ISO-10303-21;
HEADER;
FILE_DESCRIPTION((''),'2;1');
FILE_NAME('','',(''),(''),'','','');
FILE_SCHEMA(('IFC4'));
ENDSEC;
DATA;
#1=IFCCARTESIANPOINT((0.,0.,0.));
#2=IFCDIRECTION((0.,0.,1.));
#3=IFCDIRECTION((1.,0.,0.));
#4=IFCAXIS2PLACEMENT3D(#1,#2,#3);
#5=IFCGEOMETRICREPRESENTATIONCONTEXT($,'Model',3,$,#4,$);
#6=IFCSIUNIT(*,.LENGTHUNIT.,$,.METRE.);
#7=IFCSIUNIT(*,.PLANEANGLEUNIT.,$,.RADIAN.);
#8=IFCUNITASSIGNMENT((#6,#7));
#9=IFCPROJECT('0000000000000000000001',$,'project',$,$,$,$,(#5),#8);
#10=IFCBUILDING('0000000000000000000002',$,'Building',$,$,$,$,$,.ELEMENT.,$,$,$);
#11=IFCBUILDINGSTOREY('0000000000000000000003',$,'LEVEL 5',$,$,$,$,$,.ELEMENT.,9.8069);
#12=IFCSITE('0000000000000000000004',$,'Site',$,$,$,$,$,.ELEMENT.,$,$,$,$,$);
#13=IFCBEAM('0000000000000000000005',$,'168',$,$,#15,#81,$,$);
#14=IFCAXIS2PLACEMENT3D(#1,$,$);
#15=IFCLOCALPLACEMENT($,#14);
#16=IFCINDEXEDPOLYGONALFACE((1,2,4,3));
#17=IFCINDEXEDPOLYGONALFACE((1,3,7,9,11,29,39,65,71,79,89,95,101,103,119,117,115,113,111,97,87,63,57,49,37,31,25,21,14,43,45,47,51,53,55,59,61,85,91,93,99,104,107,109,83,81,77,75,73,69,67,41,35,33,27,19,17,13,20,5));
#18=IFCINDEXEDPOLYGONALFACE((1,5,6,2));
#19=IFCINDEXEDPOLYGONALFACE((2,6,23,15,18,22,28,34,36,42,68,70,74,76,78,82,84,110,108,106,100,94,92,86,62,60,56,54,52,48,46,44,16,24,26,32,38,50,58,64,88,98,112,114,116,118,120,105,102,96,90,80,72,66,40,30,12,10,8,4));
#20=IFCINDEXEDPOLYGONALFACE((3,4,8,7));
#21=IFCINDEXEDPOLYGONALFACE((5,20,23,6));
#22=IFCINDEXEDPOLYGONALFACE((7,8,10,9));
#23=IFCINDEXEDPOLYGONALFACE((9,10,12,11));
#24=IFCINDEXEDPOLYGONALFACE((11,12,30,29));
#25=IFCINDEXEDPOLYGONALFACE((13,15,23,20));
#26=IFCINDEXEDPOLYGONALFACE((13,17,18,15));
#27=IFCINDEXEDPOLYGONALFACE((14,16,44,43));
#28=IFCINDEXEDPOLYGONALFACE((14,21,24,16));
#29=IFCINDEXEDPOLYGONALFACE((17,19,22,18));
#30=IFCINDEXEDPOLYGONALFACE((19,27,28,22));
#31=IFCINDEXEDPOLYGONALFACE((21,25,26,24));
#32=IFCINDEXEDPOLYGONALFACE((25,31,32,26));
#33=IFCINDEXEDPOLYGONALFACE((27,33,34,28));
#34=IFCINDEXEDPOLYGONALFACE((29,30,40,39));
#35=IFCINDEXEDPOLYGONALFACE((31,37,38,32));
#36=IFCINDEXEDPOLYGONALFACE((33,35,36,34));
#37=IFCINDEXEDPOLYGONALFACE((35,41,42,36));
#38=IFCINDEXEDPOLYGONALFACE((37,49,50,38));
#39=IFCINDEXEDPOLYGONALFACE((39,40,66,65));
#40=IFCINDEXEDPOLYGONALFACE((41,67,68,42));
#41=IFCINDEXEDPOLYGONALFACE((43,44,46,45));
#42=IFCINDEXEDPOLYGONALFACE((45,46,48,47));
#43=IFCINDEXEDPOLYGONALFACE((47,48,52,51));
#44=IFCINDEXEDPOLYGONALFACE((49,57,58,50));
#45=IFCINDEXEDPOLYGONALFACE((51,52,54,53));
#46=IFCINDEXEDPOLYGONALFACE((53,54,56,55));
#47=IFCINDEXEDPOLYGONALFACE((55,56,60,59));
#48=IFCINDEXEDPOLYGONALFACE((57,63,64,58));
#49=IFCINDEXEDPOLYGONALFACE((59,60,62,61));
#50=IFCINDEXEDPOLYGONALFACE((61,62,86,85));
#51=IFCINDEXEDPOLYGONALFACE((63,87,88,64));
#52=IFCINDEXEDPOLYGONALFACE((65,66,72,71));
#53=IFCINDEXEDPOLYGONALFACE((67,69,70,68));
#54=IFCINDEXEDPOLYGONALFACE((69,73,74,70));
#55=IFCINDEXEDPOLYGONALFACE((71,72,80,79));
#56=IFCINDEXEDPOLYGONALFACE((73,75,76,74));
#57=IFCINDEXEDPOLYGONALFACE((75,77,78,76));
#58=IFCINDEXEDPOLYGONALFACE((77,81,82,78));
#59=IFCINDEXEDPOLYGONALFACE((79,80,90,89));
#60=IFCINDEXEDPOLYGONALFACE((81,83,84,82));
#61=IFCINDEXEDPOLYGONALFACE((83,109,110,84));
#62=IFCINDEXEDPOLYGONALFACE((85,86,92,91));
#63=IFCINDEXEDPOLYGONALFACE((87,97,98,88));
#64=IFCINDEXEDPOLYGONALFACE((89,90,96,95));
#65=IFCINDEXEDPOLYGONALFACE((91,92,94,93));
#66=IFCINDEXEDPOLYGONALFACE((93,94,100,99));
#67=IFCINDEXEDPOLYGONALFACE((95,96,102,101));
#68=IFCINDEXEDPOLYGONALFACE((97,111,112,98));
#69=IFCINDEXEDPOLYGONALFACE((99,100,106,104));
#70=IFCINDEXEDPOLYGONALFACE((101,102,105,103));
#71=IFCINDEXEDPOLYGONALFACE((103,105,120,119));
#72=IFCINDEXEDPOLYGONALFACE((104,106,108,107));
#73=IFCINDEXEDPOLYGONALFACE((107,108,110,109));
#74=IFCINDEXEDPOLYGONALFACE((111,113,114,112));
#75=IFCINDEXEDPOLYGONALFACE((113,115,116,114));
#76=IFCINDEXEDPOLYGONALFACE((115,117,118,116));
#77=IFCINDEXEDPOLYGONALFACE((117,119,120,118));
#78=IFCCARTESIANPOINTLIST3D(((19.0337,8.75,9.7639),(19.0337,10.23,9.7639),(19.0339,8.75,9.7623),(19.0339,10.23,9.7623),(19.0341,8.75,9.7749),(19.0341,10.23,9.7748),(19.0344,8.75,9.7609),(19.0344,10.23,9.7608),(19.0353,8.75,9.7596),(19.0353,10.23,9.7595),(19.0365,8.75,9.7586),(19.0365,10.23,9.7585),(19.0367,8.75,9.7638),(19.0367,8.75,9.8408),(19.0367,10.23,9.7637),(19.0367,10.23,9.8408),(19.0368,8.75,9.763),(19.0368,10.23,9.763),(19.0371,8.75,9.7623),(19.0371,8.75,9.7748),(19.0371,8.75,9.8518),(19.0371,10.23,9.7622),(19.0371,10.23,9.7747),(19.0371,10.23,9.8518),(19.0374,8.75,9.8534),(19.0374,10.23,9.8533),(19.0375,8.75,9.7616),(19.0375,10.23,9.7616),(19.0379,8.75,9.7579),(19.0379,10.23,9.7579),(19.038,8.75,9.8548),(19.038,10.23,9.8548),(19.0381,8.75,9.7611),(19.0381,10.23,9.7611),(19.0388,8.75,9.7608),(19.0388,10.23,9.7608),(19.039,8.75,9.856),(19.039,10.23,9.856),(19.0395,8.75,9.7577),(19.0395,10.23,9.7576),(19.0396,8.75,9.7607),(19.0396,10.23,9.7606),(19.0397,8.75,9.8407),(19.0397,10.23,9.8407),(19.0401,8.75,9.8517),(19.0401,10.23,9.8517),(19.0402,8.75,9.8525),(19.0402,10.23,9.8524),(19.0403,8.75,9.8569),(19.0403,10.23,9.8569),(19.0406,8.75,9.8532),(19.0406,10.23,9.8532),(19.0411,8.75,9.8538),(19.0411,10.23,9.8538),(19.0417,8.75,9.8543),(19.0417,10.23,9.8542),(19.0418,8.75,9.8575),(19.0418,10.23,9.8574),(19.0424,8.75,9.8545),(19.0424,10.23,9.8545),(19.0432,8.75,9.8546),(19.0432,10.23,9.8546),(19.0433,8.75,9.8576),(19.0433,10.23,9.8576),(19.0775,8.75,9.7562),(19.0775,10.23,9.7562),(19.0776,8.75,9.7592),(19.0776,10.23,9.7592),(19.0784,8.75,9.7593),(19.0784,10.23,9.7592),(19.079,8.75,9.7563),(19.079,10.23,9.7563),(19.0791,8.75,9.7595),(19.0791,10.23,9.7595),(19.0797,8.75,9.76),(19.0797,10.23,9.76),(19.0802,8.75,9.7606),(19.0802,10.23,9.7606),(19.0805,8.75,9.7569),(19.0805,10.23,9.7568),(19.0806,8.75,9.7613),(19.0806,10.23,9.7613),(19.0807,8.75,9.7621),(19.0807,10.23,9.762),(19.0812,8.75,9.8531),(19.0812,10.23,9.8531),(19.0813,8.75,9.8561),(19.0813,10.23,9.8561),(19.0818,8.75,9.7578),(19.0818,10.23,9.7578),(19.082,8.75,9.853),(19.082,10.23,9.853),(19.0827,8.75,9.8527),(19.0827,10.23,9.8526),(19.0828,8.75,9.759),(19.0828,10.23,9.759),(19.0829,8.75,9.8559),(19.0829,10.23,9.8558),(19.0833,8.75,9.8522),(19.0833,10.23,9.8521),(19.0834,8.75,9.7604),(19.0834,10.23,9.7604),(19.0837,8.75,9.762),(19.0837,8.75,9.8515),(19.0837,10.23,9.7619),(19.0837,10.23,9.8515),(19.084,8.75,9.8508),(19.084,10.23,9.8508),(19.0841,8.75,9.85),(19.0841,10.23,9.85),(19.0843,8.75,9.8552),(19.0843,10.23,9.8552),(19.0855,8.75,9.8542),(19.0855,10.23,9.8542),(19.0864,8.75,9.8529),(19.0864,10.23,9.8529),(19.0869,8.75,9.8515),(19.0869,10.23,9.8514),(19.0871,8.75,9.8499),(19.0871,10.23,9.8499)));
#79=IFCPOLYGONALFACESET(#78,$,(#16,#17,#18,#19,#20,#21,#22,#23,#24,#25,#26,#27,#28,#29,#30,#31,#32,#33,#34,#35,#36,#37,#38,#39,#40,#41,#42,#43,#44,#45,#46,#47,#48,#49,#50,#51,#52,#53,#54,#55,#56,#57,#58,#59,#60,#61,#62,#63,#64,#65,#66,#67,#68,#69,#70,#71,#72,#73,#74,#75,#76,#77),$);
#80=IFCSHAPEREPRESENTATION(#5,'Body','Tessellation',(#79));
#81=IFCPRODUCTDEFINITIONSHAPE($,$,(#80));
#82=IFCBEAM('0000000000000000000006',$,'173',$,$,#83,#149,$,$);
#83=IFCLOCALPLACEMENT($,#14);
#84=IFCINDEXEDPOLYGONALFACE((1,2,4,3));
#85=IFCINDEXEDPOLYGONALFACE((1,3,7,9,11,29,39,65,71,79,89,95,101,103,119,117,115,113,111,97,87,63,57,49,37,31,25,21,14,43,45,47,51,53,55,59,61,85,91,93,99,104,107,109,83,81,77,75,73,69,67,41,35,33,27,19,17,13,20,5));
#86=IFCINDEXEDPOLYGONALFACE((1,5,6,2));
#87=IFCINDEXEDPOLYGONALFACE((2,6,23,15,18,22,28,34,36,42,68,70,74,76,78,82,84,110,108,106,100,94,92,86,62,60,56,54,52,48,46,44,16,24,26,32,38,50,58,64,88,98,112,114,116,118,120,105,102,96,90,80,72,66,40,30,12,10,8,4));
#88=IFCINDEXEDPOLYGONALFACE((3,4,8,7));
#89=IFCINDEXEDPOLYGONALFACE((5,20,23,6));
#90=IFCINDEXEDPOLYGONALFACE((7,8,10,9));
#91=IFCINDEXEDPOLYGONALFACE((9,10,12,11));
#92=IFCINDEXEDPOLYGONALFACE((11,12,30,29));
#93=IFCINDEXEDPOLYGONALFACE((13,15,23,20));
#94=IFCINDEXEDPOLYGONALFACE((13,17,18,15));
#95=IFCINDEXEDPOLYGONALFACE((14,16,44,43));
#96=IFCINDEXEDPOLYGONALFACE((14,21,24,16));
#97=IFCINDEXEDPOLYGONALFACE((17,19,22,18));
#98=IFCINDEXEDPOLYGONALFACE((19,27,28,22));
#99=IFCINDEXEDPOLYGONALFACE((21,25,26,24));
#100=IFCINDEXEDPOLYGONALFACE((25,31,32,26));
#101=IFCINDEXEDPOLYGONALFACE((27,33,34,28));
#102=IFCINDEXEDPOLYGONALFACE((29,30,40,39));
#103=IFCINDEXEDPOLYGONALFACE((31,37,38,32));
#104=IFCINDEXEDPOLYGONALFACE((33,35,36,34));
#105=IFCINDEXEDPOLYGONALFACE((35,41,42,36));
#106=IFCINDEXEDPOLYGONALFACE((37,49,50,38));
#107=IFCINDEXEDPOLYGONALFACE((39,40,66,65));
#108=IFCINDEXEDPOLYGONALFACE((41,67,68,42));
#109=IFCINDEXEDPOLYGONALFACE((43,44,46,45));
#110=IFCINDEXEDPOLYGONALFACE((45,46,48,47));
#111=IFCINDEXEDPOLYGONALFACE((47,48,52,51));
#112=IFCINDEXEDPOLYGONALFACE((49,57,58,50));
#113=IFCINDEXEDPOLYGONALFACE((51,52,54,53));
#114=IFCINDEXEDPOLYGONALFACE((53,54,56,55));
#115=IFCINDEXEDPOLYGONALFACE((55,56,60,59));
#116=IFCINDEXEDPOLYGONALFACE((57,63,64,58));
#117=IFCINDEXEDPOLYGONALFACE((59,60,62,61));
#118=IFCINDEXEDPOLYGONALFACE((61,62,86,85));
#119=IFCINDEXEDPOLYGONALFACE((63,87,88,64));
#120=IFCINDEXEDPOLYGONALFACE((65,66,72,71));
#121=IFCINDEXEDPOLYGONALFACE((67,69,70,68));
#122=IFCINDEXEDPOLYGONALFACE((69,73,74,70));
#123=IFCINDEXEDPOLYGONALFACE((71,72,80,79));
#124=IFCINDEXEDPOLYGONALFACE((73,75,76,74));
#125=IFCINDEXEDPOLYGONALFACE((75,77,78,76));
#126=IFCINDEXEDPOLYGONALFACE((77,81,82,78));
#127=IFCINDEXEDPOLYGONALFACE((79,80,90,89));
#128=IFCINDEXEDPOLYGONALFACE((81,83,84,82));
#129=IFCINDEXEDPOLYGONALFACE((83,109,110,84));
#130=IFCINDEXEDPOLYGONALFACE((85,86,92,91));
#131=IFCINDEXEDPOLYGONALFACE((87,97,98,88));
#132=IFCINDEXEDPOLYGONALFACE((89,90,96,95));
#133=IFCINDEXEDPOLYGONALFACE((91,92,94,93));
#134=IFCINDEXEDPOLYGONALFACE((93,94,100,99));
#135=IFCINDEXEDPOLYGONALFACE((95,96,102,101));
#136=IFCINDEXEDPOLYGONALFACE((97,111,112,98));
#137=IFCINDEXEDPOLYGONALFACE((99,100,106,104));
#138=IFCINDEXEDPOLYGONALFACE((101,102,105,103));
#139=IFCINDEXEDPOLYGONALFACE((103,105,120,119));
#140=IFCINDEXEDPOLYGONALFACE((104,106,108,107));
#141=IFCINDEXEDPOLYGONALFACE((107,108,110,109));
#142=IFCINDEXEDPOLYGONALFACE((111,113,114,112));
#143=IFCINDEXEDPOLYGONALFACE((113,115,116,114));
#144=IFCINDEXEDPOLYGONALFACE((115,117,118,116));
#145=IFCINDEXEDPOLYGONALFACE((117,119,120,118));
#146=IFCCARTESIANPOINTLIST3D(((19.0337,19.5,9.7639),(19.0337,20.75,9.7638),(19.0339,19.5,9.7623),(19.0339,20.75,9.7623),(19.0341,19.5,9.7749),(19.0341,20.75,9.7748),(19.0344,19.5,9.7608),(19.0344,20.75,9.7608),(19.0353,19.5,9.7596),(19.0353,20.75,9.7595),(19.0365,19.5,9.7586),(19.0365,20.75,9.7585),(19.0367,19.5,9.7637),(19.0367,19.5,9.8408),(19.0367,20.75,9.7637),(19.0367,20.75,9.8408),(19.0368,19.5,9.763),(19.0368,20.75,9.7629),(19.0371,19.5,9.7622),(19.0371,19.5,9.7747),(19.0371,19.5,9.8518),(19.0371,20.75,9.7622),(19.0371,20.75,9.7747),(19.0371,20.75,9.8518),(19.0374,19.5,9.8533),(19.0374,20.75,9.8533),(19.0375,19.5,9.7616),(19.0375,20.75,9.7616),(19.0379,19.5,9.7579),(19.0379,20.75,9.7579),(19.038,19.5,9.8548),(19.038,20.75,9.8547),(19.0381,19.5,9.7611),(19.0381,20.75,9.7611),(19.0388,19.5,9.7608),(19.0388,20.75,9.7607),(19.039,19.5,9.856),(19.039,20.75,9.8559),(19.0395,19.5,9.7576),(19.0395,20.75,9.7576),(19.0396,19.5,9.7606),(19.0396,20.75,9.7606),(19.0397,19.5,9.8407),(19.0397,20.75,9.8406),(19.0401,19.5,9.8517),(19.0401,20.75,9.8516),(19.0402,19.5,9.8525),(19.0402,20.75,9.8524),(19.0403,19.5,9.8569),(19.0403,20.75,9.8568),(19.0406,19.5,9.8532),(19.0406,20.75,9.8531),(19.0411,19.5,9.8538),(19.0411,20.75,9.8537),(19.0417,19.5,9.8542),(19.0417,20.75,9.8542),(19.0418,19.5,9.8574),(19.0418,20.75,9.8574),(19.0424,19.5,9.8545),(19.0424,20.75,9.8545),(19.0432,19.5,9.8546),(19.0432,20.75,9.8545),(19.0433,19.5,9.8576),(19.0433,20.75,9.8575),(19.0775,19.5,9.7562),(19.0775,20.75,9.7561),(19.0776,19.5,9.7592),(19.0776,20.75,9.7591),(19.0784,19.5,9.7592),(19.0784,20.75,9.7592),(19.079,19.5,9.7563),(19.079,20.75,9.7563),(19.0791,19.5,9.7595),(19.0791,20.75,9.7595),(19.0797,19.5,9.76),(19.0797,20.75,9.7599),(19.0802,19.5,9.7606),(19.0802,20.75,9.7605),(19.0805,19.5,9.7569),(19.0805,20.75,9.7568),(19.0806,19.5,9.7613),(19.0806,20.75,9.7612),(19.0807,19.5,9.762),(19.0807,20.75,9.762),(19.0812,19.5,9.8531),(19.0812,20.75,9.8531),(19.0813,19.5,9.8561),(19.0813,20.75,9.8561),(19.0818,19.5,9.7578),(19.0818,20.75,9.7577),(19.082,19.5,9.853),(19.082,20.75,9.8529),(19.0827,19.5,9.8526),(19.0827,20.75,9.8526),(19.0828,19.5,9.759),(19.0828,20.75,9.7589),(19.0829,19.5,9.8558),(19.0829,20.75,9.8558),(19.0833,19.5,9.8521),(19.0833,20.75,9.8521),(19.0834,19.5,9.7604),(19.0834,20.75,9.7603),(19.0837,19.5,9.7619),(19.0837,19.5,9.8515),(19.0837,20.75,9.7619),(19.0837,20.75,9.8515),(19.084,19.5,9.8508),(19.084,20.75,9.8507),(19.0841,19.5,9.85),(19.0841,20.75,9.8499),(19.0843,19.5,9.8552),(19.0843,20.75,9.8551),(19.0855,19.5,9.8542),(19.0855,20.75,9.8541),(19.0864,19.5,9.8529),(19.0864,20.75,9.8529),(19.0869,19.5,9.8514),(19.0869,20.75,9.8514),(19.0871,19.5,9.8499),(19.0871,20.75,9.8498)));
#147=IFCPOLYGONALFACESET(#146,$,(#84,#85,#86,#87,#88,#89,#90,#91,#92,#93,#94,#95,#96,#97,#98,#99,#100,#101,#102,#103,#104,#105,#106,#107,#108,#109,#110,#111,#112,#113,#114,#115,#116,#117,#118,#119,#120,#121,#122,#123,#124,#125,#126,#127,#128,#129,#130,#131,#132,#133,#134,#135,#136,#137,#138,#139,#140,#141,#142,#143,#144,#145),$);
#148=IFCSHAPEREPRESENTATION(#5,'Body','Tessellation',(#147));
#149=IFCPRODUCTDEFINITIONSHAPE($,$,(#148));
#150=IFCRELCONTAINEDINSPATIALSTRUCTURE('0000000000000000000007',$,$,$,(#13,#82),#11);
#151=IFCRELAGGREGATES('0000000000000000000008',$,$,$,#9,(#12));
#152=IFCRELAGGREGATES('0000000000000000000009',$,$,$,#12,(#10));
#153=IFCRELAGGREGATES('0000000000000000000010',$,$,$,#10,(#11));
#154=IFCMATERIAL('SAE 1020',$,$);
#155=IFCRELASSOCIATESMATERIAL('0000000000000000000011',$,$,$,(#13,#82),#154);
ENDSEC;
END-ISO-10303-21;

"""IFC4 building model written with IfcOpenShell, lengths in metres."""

from ifc_helpers import new_model, si_unit, frame, origin_with_axes, origin_2d_with_axis, place, context, project, spatial, c_section, extrude, material, material_profile, profile_set, profile_usage, element, save


model = new_model("IFC4")

# Units and contexts
model_context = context("Model", 3, world=origin_with_axes())
ifc_project = project(units=[si_unit("LENGTHUNIT", "METRE"), si_unit("PLANEANGLEUNIT", "RADIAN")], contexts=[model_context])

# Site, building, storey
site = spatial("IfcSite", under=ifc_project, Name="Site", CompositionType="ELEMENT")
building = spatial("IfcBuilding", under=site, Name="Building", CompositionType="ELEMENT")
storey = spatial("IfcBuildingStorey", under=building, Name="LEVEL 5", CompositionType="ELEMENT", Elevation=9.8069)

# Beams
ifc_material = material(Name="SAE 1020")
ifc_material_profile_1 = material_profile(ifc_material, c_section(Depth=0.1, Width=0.05, WallThickness=0.003, Girth=0.017, InternalFilletRadius=0.003, at=origin_2d_with_axis()))
ifc_profile_set_1 = profile_set([ifc_material_profile_1])
ifc_profile_usage_1 = profile_usage(ifc_profile_set_1, cardinal=10)
beam_1_placement = place(None, frame((19.0604, 8.75, 9.8069), z_axis=(0.0, 1.0, -0.00003), x_axis=(-0.999256, 0.000001, 0.038562)))
element("IfcBeam", 1, at=beam_1_placement, inside=storey, material=ifc_profile_usage_1, Name="168", context=model_context, shape_type="SweptSolid", body=[
    extrude(c_section(Depth=0.1, Width=0.05, WallThickness=0.003, Girth=0.017, InternalFilletRadius=0.003, at=origin_2d_with_axis()), origin_with_axes(), (0.0, 0.0, 1.0), 1.48),
])
ifc_material_profile_2 = material_profile(ifc_material, c_section(Depth=0.1, Width=0.05, WallThickness=0.003, Girth=0.017, InternalFilletRadius=0.003, at=origin_2d_with_axis()))
ifc_profile_set_2 = profile_set([ifc_material_profile_2])
ifc_profile_usage_2 = profile_usage(ifc_profile_set_2, cardinal=10)
beam_2_placement = place(None, frame((19.0604, 19.5, 9.8069), z_axis=(0.0, 1.0, -0.00003), x_axis=(-0.999256, 0.000001, 0.038562)))
element("IfcBeam", 2, at=beam_2_placement, inside=storey, material=ifc_profile_usage_2, Name="173", context=model_context, shape_type="SweptSolid", body=[
    extrude(c_section(Depth=0.1, Width=0.05, WallThickness=0.003, Girth=0.017, InternalFilletRadius=0.003, at=origin_2d_with_axis()), origin_with_axes(), (0.0, 0.0, 1.0), 1.25),
])

save(model, "model.ifc")
